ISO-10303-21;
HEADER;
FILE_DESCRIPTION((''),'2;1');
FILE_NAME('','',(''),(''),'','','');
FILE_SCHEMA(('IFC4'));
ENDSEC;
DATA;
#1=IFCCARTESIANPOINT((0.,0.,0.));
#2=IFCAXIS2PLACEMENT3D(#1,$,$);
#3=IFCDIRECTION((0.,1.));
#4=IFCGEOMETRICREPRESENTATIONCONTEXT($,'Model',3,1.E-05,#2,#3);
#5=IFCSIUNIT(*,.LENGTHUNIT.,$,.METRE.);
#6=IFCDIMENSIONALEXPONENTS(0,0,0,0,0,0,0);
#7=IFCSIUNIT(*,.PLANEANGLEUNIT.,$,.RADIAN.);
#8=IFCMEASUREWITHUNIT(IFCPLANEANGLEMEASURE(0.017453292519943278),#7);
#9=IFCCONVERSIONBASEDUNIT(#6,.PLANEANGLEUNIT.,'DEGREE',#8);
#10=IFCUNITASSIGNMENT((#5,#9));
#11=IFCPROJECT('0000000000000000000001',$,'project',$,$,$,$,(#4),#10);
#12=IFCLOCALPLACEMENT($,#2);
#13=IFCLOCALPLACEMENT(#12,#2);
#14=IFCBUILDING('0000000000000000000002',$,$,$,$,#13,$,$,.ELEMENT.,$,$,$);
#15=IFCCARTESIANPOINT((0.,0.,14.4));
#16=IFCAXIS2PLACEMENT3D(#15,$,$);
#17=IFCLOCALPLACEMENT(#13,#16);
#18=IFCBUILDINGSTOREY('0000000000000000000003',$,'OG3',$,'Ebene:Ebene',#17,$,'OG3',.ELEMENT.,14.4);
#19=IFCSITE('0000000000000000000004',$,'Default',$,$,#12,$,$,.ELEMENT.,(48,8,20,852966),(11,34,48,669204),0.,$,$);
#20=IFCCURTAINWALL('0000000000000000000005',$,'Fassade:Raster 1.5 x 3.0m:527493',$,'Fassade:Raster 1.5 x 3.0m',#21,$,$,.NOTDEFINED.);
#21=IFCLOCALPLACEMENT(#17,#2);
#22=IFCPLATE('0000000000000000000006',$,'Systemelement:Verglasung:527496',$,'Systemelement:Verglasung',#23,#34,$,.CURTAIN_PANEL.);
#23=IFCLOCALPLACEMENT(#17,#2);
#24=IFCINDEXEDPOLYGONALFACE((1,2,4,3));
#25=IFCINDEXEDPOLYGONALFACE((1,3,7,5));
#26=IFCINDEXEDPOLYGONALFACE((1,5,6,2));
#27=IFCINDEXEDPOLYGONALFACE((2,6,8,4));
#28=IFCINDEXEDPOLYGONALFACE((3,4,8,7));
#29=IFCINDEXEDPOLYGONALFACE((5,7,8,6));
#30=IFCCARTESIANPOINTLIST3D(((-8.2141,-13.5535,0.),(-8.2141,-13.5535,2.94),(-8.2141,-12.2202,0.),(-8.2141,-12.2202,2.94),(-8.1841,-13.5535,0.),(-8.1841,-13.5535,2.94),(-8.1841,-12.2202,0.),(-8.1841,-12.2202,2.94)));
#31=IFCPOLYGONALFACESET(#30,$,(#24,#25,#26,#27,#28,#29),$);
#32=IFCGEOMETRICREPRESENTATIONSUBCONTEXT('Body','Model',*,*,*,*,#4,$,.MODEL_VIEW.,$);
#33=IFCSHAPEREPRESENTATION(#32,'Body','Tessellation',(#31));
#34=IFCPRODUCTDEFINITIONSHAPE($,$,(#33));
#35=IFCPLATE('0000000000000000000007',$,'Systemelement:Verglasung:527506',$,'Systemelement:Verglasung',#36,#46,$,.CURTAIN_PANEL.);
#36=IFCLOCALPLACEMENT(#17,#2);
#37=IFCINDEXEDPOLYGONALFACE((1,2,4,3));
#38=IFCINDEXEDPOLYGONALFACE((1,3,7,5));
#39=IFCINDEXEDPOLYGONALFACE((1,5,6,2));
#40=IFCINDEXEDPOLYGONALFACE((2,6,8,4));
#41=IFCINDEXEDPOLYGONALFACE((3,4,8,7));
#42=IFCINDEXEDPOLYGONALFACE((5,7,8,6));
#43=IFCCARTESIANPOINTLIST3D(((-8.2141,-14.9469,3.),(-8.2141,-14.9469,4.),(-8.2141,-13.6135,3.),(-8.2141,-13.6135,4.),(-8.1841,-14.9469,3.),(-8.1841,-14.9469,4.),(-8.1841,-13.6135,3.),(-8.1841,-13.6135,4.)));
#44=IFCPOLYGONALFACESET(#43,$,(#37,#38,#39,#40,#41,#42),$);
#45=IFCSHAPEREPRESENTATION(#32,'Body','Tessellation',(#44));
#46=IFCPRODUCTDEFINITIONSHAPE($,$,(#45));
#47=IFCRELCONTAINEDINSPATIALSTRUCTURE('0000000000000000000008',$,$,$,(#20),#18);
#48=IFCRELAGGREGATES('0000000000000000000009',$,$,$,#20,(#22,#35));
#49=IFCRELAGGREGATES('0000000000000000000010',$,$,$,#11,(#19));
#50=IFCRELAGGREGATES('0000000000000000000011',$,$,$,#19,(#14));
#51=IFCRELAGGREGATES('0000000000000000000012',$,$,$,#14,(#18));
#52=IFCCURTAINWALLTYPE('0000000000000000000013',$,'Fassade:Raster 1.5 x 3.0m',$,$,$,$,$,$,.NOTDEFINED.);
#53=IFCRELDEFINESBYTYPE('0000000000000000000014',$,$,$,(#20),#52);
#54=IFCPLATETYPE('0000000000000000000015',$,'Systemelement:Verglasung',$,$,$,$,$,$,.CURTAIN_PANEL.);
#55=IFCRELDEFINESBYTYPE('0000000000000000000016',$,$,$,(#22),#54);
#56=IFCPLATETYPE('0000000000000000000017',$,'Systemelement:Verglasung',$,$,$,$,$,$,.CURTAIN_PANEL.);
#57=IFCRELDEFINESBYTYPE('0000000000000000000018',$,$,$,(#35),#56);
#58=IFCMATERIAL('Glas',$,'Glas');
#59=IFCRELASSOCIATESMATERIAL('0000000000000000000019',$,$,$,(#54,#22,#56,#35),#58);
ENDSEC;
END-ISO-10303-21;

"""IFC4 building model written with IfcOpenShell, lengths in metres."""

from ifc_helpers import new_model, entity, si_unit, converted_unit, direction, frame, origin, place, context, subcontext, project, spatial, indexed_curve, outline, extrude, source, transform, mapped, material, type_object, type_shapes, element, aggregate, save


model = new_model("IFC4")

# Units and contexts
model_context = context("Model", 3, precision=1e-05, world=origin(), true_north=direction((0.0, 1.0)))
body_context = subcontext(model_context, "Body", "Model", "MODEL_VIEW")
ifc_project = project(units=[si_unit("LENGTHUNIT", "METRE"), converted_unit("PLANEANGLEUNIT", "DEGREE", entity("IfcPlaneAngleMeasure", 0.017453292519943278), si_unit("PLANEANGLEUNIT", "RADIAN"), dimensions=[0, 0, 0, 0, 0, 0, 0])], contexts=[model_context])

# Site, building, storey
site_placement = place(None, origin())
site = spatial("IfcSite", under=ifc_project, at=site_placement, Name="Default", CompositionType="ELEMENT", RefLatitude=(48, 8, 20, 852966), RefLongitude=(11, 34, 48, 669204), RefElevation=0.0)
building_placement = place(site_placement, origin())
building = spatial("IfcBuilding", under=site, at=building_placement, CompositionType="ELEMENT")
storey_placement = place(building_placement, frame((0.0, 0.0, 14.4)))
storey = spatial("IfcBuildingStorey", under=building, at=storey_placement, Name="OG3", ObjectType="Ebene:Ebene", LongName="OG3", CompositionType="ELEMENT", Elevation=14.4)

# Shared definitions
curtain_wall_type = type_object("IfcCurtainWallType", Name="Fassade:Raster 1.5 x 3.0m", PredefinedType="NOTDEFINED")

# Curtain wall
curtain_wall_1_placement = place(storey_placement, frame((0.0, 0.0, -14.4)))
curtain_wall_1 = element("IfcCurtainWall", 1, at=curtain_wall_1_placement, inside=storey, type_object=curtain_wall_type, Name="Fassade:Raster 1.5 x 3.0m:527493", ObjectType="Fassade:Raster 1.5 x 3.0m", PredefinedType="NOTDEFINED")

# Plates
ifc_material_1 = material(Name="Glas", Category="Glas")
plate_type_1 = type_object("IfcPlateType", Name="Systemelement:Verglasung", PredefinedType="CURTAIN_PANEL", material=ifc_material_1)
shared_shape_1 = source(origin(), body_context, "Body", "SweptSolid", [
    extrude(outline(indexed_curve([(-0.015, -0.6667), (0.015, -0.6667), (0.015, 0.6667), (-0.015, 0.6667), (-0.015, -0.6667)], self_intersect=False)), frame((0.0, 0.0, 0.0), z_axis=(0.0, 0.0, 1.0), x_axis=(0.0, 1.0, 0.0)), (0.0, 0.0, 1.0), 2.94),
])
type_shapes(plate_type_1, [shared_shape_1])
plate_1_placement = place(curtain_wall_1_placement, frame((-8.1991, -12.8869, 14.4), z_axis=(0.0, 0.0, 1.0), x_axis=(0.0, 1.0, 0.0)))
plate_1 = element("IfcPlate", 2, at=plate_1_placement, type_object=plate_type_1, material=ifc_material_1, Name="Systemelement:Verglasung:527496", ObjectType="Systemelement:Verglasung", PredefinedType="CURTAIN_PANEL", context=body_context, shape_type="MappedRepresentation", body=[
    mapped(shared_shape_1, transform((0.0, 0.0, 0.0), scale=1.0)),
])
plate_type_2 = type_object("IfcPlateType", Name="Systemelement:Verglasung", PredefinedType="CURTAIN_PANEL", material=ifc_material_1)
shared_shape_2 = source(origin(), body_context, "Body", "SweptSolid", [
    extrude(outline(indexed_curve([(-0.015, -0.6667), (0.015, -0.6667), (0.015, 0.6667), (-0.015, 0.6667), (-0.015, -0.6667)], self_intersect=False)), frame((0.0, 0.0, 0.0), z_axis=(0.0, 0.0, 1.0), x_axis=(0.0, 1.0, 0.0)), (0.0, 0.0, 1.0), 1.0),
])
type_shapes(plate_type_2, [shared_shape_2])
plate_2_placement = place(curtain_wall_1_placement, frame((-8.1991, -14.2802, 17.4), z_axis=(0.0, 0.0, 1.0), x_axis=(0.0, 1.0, 0.0)))
plate_2 = element("IfcPlate", 3, at=plate_2_placement, type_object=plate_type_2, material=ifc_material_1, Name="Systemelement:Verglasung:527506", ObjectType="Systemelement:Verglasung", PredefinedType="CURTAIN_PANEL", context=body_context, shape_type="MappedRepresentation", body=[
    mapped(shared_shape_2, transform((0.0, 0.0, 0.0), scale=1.0)),
])
aggregate(curtain_wall_1, [plate_1, plate_2])

save(model, "model.ifc")
